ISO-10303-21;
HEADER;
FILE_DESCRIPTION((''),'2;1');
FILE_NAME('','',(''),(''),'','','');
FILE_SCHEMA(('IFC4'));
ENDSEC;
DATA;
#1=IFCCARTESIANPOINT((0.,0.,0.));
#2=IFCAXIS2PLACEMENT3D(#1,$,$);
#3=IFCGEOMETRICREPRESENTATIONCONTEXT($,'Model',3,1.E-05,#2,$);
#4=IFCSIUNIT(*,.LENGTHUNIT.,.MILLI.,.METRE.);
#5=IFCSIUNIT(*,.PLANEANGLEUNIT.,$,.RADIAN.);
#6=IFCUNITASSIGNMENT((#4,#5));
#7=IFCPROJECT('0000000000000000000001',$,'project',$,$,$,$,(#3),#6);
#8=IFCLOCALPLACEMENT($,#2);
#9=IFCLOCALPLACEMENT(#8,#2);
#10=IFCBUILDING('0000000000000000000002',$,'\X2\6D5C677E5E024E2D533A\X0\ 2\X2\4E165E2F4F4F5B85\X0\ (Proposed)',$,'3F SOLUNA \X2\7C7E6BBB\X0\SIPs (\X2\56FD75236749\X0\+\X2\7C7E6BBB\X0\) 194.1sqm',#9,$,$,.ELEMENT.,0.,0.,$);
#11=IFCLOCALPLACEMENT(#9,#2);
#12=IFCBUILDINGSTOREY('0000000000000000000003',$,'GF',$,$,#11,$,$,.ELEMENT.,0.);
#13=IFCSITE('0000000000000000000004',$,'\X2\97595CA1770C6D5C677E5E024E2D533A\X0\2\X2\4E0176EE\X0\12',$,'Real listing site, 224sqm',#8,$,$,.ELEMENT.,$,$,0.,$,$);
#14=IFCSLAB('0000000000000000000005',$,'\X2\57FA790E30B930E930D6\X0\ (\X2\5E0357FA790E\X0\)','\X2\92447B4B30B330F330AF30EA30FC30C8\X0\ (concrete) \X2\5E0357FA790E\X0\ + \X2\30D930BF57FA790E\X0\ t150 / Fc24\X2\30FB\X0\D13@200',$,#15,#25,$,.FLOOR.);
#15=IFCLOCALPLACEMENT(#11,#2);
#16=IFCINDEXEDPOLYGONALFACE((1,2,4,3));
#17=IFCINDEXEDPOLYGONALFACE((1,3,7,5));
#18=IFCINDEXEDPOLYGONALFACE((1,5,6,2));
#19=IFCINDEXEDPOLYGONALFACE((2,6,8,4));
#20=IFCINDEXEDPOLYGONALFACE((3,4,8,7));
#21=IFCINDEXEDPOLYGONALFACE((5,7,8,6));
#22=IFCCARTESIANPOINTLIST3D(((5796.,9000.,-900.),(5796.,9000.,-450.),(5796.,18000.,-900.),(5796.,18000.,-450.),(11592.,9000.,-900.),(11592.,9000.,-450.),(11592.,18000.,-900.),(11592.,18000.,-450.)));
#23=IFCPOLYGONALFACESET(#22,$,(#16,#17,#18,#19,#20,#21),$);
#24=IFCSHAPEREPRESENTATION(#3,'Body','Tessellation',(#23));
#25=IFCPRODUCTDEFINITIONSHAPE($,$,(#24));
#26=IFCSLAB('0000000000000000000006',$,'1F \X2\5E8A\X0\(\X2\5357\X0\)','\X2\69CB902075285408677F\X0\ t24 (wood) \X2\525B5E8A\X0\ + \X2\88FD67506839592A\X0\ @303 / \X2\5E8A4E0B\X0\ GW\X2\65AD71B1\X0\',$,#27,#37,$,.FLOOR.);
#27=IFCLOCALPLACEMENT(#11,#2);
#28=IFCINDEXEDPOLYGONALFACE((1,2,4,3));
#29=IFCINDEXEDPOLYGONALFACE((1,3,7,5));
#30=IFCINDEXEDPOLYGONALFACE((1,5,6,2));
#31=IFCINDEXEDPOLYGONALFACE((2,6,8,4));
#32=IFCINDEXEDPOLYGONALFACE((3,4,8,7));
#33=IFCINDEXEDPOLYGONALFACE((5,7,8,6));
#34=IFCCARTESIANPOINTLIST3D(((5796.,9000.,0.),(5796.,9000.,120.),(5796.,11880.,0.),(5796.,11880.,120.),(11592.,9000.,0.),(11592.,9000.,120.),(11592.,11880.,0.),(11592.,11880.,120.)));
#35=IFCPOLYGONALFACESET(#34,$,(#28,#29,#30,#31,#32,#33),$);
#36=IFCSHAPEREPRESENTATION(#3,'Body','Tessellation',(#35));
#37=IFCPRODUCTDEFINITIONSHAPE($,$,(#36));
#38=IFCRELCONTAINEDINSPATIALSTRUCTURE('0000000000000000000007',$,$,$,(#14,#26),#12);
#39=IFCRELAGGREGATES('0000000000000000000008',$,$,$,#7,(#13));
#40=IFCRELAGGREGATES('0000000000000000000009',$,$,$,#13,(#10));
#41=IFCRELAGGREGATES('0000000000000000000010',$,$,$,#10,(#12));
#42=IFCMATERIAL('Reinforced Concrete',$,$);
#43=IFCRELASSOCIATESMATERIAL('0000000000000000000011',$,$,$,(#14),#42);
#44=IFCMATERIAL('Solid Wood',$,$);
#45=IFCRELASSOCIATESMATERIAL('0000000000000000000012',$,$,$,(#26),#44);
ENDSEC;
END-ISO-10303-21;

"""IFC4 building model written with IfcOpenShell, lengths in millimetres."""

from ifc_helpers import new_model, si_unit, frame, frame_2d, origin, place, context, project, spatial, rectangle, extrude, material, element, save


model = new_model("IFC4")

# Units and contexts
model_context = context("Model", 3, precision=1e-05, world=origin())
ifc_project = project(units=[si_unit("LENGTHUNIT", "METRE", prefix="MILLI"), si_unit("PLANEANGLEUNIT", "RADIAN")], contexts=[model_context])

# Site, building, storey
site_placement = place(None, origin())
site = spatial("IfcSite", under=ifc_project, at=site_placement, Name="静岡県浜松市中区2丁目12", ObjectType="Real listing site, 224sqm", CompositionType="ELEMENT", RefElevation=0.0)
building_placement = place(site_placement, origin())
building = spatial("IfcBuilding", under=site, at=building_placement, Name="浜松市中区 2世帯住宅 (Proposed)", ObjectType="3F SOLUNA 籾殻SIPs (国産杉+籾殻) 194.1sqm", CompositionType="ELEMENT", ElevationOfRefHeight=0.0, ElevationOfTerrain=0.0)
storey_placement = place(building_placement, origin())
storey = spatial("IfcBuildingStorey", under=building, at=storey_placement, Name="GF", CompositionType="ELEMENT", Elevation=0.0)

# Slabs
ifc_material_1 = material(Name="Reinforced Concrete")
slab_1_placement = place(storey_placement, frame((2898.0, 4500.0, -450.0)))
element("IfcSlab", 1, at=slab_1_placement, inside=storey, material=ifc_material_1, Name="基礎スラブ (布基礎)", Description="鉄筋コンクリート (concrete) 布基礎 + ベタ基礎 t150 / Fc24・D13@200", PredefinedType="FLOOR", context=model_context, shape_type="SweptSolid", body=[
    extrude(rectangle(XDim=5796.0, YDim=9000.0, at=frame_2d((2898.0, 4500.0))), frame((2898.0, 4500.0, -450.0)), (0.0, 0.0, 1.0), 450.0),
])
ifc_material_2 = material(Name="Solid Wood")
slab_2_placement = place(storey_placement, frame((2898.0, 4500.0, 0.0)))
element("IfcSlab", 2, at=slab_2_placement, inside=storey, material=ifc_material_2, Name="1F 床(南)", Description="構造用合板 t24 (wood) 剛床 + 製材根太 @303 / 床下 GW断熱", PredefinedType="FLOOR", context=model_context, shape_type="SweptSolid", body=[
    extrude(rectangle(XDim=5796.0, YDim=2880.0, at=frame_2d((2898.0, 1440.0))), frame((2898.0, 4500.0, 0.0)), (0.0, 0.0, 1.0), 120.0),
])

save(model, "model.ifc")
